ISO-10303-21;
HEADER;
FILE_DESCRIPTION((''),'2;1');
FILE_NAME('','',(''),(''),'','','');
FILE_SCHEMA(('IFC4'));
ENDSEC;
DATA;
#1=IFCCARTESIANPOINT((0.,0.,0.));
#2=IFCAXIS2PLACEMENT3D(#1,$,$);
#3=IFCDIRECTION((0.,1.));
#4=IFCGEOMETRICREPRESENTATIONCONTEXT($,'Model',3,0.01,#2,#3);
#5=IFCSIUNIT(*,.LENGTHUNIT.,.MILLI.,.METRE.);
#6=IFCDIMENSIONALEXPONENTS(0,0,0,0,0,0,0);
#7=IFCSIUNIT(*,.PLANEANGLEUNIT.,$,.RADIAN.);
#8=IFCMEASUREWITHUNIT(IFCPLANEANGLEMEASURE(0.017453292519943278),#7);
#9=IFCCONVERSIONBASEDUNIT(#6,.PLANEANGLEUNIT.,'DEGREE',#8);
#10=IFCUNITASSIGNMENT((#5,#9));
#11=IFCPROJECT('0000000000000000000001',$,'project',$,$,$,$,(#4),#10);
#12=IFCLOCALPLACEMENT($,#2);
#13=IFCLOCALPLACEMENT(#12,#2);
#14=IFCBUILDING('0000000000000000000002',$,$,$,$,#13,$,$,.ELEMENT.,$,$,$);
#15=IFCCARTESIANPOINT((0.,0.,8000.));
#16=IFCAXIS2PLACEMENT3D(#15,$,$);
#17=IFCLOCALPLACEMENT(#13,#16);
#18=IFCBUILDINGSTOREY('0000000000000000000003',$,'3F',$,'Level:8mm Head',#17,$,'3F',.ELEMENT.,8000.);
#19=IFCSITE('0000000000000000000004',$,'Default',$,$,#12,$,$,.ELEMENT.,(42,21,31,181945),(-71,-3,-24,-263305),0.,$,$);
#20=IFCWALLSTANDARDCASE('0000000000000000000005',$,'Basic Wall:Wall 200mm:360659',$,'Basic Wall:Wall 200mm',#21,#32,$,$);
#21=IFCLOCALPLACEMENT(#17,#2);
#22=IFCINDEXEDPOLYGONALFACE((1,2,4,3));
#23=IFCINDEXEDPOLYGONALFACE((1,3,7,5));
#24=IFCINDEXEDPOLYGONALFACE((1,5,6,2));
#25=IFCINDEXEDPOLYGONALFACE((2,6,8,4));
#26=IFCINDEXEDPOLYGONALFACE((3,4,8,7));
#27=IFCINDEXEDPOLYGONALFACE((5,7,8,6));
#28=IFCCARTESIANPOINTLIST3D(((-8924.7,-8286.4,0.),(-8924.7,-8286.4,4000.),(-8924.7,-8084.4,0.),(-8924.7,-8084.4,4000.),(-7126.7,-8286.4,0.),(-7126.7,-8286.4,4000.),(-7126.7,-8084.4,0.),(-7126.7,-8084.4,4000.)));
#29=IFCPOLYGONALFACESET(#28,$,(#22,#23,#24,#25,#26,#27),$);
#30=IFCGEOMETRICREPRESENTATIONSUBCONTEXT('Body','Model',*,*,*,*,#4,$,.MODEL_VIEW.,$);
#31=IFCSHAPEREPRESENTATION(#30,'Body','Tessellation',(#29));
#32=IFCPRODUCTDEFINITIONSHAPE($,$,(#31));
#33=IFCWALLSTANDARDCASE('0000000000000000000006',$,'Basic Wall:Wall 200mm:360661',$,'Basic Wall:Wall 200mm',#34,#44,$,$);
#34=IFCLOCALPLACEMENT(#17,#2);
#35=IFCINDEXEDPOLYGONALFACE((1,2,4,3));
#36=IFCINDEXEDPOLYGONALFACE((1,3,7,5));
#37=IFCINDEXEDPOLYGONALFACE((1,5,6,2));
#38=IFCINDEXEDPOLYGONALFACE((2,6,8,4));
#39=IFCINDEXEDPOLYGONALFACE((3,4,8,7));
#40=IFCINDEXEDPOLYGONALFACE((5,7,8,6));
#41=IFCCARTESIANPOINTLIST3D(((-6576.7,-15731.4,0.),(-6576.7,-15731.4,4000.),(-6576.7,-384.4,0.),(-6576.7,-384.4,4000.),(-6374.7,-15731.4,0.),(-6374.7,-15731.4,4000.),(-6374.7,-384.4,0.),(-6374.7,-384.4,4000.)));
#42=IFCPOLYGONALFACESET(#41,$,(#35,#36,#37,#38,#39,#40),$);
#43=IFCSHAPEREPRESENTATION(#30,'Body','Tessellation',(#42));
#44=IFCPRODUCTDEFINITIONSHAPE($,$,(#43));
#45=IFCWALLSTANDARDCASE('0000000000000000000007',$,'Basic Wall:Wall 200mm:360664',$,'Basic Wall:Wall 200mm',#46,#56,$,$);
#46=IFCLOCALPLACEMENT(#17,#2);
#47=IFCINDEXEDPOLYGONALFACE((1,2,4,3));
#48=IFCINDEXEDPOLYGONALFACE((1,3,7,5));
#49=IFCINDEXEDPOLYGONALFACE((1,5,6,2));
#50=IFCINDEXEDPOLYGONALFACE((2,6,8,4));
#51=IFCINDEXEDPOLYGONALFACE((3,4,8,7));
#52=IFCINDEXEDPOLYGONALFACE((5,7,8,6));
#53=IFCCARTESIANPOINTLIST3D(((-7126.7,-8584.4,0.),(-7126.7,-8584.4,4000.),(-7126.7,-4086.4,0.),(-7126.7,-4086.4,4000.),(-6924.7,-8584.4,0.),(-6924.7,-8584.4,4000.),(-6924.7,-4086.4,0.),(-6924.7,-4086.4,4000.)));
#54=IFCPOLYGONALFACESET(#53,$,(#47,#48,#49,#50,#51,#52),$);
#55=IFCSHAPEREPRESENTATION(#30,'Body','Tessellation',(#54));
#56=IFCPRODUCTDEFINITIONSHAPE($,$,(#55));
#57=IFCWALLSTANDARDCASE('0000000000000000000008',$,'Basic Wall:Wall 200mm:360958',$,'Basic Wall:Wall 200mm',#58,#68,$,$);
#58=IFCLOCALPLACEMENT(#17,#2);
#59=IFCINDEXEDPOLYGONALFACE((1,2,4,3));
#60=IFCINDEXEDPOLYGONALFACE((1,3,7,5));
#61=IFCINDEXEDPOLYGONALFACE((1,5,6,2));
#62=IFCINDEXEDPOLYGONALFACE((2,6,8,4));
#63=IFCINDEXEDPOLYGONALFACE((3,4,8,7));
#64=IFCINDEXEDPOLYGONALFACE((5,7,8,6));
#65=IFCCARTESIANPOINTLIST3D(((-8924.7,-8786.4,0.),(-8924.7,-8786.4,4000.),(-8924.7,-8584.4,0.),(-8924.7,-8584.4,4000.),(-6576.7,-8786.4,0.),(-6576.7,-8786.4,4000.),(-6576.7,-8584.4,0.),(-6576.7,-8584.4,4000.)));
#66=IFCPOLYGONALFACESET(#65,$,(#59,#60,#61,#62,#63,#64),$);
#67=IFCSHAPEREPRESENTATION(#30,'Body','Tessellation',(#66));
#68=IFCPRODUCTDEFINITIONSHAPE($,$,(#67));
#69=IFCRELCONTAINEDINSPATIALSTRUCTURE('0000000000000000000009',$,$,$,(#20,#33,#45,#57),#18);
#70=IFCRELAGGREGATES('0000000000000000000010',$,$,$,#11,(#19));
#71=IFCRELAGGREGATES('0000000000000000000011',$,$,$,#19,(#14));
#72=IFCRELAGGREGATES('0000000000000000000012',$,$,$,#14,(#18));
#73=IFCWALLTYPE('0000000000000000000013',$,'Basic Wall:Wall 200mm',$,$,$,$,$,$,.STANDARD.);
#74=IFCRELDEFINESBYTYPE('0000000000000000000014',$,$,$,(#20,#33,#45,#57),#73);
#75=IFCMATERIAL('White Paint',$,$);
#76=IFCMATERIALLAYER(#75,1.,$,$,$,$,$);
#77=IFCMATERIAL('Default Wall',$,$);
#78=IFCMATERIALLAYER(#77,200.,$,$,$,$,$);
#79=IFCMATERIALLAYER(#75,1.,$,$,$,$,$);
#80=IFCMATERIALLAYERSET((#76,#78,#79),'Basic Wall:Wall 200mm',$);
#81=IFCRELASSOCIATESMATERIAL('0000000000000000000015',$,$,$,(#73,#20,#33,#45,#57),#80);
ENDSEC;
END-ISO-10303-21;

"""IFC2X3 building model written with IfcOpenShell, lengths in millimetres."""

from ifc_helpers import new_model, entity, si_unit, converted_unit, direction, frame, frame_2d, origin, place, context, subcontext, project, spatial, rectangle, extrude, material, layer, layer_set, layer_usage, type_object, element, save


model = new_model("IFC2X3")

# Units and contexts
model_context = context("Model", 3, precision=0.01, world=origin(), true_north=direction((0.0, 1.0)))
body_context = subcontext(model_context, "Body", "Model", "MODEL_VIEW")
ifc_project = project(units=[si_unit("LENGTHUNIT", "METRE", prefix="MILLI"), converted_unit("PLANEANGLEUNIT", "DEGREE", entity("IfcPlaneAngleMeasure", 0.017453292519943278), si_unit("PLANEANGLEUNIT", "RADIAN"), dimensions=[0, 0, 0, 0, 0, 0, 0])], contexts=[model_context])

# Site, building, storey
site_placement = place(None, origin())
site = spatial("IfcSite", under=ifc_project, at=site_placement, Name="Default", CompositionType="ELEMENT", RefLatitude=(42, 21, 31, 181945), RefLongitude=(-71, -3, -24, -263305), RefElevation=0.0)
building_placement = place(site_placement, origin())
building = spatial("IfcBuilding", under=site, at=building_placement, CompositionType="ELEMENT")
storey_placement = place(building_placement, frame((0.0, 0.0, 8000.0)))
storey = spatial("IfcBuildingStorey", under=building, at=storey_placement, Name="3F", ObjectType="Level:8mm Head", LongName="3F", CompositionType="ELEMENT", Elevation=8000.0)

# Shared definitions
ifc_material_1 = material(Name="White Paint")

# Walls
ifc_layer_1 = layer(ifc_material_1, 1.0)
ifc_material_2 = material(Name="Default Wall")
ifc_layer_2 = layer(ifc_material_2, 200.0)
ifc_layer_3 = layer(ifc_material_1, 1.0)
ifc_layer_set = layer_set([ifc_layer_1, ifc_layer_2, ifc_layer_3], Name="Basic Wall:Wall 200mm")
wall_type = type_object("IfcWallType", Name="Basic Wall:Wall 200mm", PredefinedType="STANDARD", material=ifc_layer_set)
ifc_layer_usage_1 = layer_usage(ifc_layer_set, "AXIS2", "NEGATIVE", 101.0)
wall_1_placement = place(storey_placement, frame((-7126.7, -8185.4, 0.0), z_axis=(0.0, 0.0, 1.0), x_axis=(-1.0, 0.0, 0.0)))
element("IfcWallStandardCase", 1, at=wall_1_placement, inside=storey, type_object=wall_type, material=ifc_layer_usage_1, Name="Basic Wall:Wall 200mm:360659", ObjectType="Basic Wall:Wall 200mm", context=body_context, shape_type="SweptSolid", body=[
    extrude(rectangle(XDim=1798.0, YDim=202.0, at=frame_2d((899.0, 0.0), x_axis=(-1.0, 0.0))), origin(), (0.0, 0.0, 1.0), 4000.0),
])
ifc_layer_usage_2 = layer_usage(ifc_layer_set, "AXIS2", "NEGATIVE", 101.0)
wall_2_placement = place(storey_placement, frame((-6475.7, -384.4, 0.0), z_axis=(0.0, 0.0, 1.0), x_axis=(0.0, -1.0, 0.0)))
element("IfcWallStandardCase", 2, at=wall_2_placement, inside=storey, type_object=wall_type, material=ifc_layer_usage_2, Name="Basic Wall:Wall 200mm:360661", ObjectType="Basic Wall:Wall 200mm", context=body_context, shape_type="SweptSolid", body=[
    extrude(rectangle(XDim=15347.0, YDim=202.0, at=frame_2d((7673.5, 0.0), x_axis=(-1.0, 0.0))), origin(), (0.0, 0.0, 1.0), 4000.0),
])
ifc_layer_usage_3 = layer_usage(ifc_layer_set, "AXIS2", "NEGATIVE", 101.0)
wall_3_placement = place(storey_placement, frame((-7025.7, -4086.4, 0.0), z_axis=(0.0, 0.0, 1.0), x_axis=(0.0, -1.0, 0.0)))
element("IfcWallStandardCase", 3, at=wall_3_placement, inside=storey, type_object=wall_type, material=ifc_layer_usage_3, Name="Basic Wall:Wall 200mm:360664", ObjectType="Basic Wall:Wall 200mm", context=body_context, shape_type="SweptSolid", body=[
    extrude(rectangle(XDim=4498.0, YDim=202.0, at=frame_2d((2249.0, 0.0), x_axis=(-1.0, 0.0))), origin(), (0.0, 0.0, 1.0), 4000.0),
])
ifc_layer_usage_4 = layer_usage(ifc_layer_set, "AXIS2", "NEGATIVE", 101.0)
wall_4_placement = place(storey_placement, frame((-6576.7, -8685.4, 0.0), z_axis=(0.0, 0.0, 1.0), x_axis=(-1.0, 0.0, 0.0)))
element("IfcWallStandardCase", 4, at=wall_4_placement, inside=storey, type_object=wall_type, material=ifc_layer_usage_4, Name="Basic Wall:Wall 200mm:360958", ObjectType="Basic Wall:Wall 200mm", context=body_context, shape_type="SweptSolid", body=[
    extrude(rectangle(XDim=2348.0, YDim=202.0, at=frame_2d((1174.0, 0.0), x_axis=(-1.0, 0.0))), origin(), (0.0, 0.0, 1.0), 4000.0),
])

save(model, "model.ifc")
